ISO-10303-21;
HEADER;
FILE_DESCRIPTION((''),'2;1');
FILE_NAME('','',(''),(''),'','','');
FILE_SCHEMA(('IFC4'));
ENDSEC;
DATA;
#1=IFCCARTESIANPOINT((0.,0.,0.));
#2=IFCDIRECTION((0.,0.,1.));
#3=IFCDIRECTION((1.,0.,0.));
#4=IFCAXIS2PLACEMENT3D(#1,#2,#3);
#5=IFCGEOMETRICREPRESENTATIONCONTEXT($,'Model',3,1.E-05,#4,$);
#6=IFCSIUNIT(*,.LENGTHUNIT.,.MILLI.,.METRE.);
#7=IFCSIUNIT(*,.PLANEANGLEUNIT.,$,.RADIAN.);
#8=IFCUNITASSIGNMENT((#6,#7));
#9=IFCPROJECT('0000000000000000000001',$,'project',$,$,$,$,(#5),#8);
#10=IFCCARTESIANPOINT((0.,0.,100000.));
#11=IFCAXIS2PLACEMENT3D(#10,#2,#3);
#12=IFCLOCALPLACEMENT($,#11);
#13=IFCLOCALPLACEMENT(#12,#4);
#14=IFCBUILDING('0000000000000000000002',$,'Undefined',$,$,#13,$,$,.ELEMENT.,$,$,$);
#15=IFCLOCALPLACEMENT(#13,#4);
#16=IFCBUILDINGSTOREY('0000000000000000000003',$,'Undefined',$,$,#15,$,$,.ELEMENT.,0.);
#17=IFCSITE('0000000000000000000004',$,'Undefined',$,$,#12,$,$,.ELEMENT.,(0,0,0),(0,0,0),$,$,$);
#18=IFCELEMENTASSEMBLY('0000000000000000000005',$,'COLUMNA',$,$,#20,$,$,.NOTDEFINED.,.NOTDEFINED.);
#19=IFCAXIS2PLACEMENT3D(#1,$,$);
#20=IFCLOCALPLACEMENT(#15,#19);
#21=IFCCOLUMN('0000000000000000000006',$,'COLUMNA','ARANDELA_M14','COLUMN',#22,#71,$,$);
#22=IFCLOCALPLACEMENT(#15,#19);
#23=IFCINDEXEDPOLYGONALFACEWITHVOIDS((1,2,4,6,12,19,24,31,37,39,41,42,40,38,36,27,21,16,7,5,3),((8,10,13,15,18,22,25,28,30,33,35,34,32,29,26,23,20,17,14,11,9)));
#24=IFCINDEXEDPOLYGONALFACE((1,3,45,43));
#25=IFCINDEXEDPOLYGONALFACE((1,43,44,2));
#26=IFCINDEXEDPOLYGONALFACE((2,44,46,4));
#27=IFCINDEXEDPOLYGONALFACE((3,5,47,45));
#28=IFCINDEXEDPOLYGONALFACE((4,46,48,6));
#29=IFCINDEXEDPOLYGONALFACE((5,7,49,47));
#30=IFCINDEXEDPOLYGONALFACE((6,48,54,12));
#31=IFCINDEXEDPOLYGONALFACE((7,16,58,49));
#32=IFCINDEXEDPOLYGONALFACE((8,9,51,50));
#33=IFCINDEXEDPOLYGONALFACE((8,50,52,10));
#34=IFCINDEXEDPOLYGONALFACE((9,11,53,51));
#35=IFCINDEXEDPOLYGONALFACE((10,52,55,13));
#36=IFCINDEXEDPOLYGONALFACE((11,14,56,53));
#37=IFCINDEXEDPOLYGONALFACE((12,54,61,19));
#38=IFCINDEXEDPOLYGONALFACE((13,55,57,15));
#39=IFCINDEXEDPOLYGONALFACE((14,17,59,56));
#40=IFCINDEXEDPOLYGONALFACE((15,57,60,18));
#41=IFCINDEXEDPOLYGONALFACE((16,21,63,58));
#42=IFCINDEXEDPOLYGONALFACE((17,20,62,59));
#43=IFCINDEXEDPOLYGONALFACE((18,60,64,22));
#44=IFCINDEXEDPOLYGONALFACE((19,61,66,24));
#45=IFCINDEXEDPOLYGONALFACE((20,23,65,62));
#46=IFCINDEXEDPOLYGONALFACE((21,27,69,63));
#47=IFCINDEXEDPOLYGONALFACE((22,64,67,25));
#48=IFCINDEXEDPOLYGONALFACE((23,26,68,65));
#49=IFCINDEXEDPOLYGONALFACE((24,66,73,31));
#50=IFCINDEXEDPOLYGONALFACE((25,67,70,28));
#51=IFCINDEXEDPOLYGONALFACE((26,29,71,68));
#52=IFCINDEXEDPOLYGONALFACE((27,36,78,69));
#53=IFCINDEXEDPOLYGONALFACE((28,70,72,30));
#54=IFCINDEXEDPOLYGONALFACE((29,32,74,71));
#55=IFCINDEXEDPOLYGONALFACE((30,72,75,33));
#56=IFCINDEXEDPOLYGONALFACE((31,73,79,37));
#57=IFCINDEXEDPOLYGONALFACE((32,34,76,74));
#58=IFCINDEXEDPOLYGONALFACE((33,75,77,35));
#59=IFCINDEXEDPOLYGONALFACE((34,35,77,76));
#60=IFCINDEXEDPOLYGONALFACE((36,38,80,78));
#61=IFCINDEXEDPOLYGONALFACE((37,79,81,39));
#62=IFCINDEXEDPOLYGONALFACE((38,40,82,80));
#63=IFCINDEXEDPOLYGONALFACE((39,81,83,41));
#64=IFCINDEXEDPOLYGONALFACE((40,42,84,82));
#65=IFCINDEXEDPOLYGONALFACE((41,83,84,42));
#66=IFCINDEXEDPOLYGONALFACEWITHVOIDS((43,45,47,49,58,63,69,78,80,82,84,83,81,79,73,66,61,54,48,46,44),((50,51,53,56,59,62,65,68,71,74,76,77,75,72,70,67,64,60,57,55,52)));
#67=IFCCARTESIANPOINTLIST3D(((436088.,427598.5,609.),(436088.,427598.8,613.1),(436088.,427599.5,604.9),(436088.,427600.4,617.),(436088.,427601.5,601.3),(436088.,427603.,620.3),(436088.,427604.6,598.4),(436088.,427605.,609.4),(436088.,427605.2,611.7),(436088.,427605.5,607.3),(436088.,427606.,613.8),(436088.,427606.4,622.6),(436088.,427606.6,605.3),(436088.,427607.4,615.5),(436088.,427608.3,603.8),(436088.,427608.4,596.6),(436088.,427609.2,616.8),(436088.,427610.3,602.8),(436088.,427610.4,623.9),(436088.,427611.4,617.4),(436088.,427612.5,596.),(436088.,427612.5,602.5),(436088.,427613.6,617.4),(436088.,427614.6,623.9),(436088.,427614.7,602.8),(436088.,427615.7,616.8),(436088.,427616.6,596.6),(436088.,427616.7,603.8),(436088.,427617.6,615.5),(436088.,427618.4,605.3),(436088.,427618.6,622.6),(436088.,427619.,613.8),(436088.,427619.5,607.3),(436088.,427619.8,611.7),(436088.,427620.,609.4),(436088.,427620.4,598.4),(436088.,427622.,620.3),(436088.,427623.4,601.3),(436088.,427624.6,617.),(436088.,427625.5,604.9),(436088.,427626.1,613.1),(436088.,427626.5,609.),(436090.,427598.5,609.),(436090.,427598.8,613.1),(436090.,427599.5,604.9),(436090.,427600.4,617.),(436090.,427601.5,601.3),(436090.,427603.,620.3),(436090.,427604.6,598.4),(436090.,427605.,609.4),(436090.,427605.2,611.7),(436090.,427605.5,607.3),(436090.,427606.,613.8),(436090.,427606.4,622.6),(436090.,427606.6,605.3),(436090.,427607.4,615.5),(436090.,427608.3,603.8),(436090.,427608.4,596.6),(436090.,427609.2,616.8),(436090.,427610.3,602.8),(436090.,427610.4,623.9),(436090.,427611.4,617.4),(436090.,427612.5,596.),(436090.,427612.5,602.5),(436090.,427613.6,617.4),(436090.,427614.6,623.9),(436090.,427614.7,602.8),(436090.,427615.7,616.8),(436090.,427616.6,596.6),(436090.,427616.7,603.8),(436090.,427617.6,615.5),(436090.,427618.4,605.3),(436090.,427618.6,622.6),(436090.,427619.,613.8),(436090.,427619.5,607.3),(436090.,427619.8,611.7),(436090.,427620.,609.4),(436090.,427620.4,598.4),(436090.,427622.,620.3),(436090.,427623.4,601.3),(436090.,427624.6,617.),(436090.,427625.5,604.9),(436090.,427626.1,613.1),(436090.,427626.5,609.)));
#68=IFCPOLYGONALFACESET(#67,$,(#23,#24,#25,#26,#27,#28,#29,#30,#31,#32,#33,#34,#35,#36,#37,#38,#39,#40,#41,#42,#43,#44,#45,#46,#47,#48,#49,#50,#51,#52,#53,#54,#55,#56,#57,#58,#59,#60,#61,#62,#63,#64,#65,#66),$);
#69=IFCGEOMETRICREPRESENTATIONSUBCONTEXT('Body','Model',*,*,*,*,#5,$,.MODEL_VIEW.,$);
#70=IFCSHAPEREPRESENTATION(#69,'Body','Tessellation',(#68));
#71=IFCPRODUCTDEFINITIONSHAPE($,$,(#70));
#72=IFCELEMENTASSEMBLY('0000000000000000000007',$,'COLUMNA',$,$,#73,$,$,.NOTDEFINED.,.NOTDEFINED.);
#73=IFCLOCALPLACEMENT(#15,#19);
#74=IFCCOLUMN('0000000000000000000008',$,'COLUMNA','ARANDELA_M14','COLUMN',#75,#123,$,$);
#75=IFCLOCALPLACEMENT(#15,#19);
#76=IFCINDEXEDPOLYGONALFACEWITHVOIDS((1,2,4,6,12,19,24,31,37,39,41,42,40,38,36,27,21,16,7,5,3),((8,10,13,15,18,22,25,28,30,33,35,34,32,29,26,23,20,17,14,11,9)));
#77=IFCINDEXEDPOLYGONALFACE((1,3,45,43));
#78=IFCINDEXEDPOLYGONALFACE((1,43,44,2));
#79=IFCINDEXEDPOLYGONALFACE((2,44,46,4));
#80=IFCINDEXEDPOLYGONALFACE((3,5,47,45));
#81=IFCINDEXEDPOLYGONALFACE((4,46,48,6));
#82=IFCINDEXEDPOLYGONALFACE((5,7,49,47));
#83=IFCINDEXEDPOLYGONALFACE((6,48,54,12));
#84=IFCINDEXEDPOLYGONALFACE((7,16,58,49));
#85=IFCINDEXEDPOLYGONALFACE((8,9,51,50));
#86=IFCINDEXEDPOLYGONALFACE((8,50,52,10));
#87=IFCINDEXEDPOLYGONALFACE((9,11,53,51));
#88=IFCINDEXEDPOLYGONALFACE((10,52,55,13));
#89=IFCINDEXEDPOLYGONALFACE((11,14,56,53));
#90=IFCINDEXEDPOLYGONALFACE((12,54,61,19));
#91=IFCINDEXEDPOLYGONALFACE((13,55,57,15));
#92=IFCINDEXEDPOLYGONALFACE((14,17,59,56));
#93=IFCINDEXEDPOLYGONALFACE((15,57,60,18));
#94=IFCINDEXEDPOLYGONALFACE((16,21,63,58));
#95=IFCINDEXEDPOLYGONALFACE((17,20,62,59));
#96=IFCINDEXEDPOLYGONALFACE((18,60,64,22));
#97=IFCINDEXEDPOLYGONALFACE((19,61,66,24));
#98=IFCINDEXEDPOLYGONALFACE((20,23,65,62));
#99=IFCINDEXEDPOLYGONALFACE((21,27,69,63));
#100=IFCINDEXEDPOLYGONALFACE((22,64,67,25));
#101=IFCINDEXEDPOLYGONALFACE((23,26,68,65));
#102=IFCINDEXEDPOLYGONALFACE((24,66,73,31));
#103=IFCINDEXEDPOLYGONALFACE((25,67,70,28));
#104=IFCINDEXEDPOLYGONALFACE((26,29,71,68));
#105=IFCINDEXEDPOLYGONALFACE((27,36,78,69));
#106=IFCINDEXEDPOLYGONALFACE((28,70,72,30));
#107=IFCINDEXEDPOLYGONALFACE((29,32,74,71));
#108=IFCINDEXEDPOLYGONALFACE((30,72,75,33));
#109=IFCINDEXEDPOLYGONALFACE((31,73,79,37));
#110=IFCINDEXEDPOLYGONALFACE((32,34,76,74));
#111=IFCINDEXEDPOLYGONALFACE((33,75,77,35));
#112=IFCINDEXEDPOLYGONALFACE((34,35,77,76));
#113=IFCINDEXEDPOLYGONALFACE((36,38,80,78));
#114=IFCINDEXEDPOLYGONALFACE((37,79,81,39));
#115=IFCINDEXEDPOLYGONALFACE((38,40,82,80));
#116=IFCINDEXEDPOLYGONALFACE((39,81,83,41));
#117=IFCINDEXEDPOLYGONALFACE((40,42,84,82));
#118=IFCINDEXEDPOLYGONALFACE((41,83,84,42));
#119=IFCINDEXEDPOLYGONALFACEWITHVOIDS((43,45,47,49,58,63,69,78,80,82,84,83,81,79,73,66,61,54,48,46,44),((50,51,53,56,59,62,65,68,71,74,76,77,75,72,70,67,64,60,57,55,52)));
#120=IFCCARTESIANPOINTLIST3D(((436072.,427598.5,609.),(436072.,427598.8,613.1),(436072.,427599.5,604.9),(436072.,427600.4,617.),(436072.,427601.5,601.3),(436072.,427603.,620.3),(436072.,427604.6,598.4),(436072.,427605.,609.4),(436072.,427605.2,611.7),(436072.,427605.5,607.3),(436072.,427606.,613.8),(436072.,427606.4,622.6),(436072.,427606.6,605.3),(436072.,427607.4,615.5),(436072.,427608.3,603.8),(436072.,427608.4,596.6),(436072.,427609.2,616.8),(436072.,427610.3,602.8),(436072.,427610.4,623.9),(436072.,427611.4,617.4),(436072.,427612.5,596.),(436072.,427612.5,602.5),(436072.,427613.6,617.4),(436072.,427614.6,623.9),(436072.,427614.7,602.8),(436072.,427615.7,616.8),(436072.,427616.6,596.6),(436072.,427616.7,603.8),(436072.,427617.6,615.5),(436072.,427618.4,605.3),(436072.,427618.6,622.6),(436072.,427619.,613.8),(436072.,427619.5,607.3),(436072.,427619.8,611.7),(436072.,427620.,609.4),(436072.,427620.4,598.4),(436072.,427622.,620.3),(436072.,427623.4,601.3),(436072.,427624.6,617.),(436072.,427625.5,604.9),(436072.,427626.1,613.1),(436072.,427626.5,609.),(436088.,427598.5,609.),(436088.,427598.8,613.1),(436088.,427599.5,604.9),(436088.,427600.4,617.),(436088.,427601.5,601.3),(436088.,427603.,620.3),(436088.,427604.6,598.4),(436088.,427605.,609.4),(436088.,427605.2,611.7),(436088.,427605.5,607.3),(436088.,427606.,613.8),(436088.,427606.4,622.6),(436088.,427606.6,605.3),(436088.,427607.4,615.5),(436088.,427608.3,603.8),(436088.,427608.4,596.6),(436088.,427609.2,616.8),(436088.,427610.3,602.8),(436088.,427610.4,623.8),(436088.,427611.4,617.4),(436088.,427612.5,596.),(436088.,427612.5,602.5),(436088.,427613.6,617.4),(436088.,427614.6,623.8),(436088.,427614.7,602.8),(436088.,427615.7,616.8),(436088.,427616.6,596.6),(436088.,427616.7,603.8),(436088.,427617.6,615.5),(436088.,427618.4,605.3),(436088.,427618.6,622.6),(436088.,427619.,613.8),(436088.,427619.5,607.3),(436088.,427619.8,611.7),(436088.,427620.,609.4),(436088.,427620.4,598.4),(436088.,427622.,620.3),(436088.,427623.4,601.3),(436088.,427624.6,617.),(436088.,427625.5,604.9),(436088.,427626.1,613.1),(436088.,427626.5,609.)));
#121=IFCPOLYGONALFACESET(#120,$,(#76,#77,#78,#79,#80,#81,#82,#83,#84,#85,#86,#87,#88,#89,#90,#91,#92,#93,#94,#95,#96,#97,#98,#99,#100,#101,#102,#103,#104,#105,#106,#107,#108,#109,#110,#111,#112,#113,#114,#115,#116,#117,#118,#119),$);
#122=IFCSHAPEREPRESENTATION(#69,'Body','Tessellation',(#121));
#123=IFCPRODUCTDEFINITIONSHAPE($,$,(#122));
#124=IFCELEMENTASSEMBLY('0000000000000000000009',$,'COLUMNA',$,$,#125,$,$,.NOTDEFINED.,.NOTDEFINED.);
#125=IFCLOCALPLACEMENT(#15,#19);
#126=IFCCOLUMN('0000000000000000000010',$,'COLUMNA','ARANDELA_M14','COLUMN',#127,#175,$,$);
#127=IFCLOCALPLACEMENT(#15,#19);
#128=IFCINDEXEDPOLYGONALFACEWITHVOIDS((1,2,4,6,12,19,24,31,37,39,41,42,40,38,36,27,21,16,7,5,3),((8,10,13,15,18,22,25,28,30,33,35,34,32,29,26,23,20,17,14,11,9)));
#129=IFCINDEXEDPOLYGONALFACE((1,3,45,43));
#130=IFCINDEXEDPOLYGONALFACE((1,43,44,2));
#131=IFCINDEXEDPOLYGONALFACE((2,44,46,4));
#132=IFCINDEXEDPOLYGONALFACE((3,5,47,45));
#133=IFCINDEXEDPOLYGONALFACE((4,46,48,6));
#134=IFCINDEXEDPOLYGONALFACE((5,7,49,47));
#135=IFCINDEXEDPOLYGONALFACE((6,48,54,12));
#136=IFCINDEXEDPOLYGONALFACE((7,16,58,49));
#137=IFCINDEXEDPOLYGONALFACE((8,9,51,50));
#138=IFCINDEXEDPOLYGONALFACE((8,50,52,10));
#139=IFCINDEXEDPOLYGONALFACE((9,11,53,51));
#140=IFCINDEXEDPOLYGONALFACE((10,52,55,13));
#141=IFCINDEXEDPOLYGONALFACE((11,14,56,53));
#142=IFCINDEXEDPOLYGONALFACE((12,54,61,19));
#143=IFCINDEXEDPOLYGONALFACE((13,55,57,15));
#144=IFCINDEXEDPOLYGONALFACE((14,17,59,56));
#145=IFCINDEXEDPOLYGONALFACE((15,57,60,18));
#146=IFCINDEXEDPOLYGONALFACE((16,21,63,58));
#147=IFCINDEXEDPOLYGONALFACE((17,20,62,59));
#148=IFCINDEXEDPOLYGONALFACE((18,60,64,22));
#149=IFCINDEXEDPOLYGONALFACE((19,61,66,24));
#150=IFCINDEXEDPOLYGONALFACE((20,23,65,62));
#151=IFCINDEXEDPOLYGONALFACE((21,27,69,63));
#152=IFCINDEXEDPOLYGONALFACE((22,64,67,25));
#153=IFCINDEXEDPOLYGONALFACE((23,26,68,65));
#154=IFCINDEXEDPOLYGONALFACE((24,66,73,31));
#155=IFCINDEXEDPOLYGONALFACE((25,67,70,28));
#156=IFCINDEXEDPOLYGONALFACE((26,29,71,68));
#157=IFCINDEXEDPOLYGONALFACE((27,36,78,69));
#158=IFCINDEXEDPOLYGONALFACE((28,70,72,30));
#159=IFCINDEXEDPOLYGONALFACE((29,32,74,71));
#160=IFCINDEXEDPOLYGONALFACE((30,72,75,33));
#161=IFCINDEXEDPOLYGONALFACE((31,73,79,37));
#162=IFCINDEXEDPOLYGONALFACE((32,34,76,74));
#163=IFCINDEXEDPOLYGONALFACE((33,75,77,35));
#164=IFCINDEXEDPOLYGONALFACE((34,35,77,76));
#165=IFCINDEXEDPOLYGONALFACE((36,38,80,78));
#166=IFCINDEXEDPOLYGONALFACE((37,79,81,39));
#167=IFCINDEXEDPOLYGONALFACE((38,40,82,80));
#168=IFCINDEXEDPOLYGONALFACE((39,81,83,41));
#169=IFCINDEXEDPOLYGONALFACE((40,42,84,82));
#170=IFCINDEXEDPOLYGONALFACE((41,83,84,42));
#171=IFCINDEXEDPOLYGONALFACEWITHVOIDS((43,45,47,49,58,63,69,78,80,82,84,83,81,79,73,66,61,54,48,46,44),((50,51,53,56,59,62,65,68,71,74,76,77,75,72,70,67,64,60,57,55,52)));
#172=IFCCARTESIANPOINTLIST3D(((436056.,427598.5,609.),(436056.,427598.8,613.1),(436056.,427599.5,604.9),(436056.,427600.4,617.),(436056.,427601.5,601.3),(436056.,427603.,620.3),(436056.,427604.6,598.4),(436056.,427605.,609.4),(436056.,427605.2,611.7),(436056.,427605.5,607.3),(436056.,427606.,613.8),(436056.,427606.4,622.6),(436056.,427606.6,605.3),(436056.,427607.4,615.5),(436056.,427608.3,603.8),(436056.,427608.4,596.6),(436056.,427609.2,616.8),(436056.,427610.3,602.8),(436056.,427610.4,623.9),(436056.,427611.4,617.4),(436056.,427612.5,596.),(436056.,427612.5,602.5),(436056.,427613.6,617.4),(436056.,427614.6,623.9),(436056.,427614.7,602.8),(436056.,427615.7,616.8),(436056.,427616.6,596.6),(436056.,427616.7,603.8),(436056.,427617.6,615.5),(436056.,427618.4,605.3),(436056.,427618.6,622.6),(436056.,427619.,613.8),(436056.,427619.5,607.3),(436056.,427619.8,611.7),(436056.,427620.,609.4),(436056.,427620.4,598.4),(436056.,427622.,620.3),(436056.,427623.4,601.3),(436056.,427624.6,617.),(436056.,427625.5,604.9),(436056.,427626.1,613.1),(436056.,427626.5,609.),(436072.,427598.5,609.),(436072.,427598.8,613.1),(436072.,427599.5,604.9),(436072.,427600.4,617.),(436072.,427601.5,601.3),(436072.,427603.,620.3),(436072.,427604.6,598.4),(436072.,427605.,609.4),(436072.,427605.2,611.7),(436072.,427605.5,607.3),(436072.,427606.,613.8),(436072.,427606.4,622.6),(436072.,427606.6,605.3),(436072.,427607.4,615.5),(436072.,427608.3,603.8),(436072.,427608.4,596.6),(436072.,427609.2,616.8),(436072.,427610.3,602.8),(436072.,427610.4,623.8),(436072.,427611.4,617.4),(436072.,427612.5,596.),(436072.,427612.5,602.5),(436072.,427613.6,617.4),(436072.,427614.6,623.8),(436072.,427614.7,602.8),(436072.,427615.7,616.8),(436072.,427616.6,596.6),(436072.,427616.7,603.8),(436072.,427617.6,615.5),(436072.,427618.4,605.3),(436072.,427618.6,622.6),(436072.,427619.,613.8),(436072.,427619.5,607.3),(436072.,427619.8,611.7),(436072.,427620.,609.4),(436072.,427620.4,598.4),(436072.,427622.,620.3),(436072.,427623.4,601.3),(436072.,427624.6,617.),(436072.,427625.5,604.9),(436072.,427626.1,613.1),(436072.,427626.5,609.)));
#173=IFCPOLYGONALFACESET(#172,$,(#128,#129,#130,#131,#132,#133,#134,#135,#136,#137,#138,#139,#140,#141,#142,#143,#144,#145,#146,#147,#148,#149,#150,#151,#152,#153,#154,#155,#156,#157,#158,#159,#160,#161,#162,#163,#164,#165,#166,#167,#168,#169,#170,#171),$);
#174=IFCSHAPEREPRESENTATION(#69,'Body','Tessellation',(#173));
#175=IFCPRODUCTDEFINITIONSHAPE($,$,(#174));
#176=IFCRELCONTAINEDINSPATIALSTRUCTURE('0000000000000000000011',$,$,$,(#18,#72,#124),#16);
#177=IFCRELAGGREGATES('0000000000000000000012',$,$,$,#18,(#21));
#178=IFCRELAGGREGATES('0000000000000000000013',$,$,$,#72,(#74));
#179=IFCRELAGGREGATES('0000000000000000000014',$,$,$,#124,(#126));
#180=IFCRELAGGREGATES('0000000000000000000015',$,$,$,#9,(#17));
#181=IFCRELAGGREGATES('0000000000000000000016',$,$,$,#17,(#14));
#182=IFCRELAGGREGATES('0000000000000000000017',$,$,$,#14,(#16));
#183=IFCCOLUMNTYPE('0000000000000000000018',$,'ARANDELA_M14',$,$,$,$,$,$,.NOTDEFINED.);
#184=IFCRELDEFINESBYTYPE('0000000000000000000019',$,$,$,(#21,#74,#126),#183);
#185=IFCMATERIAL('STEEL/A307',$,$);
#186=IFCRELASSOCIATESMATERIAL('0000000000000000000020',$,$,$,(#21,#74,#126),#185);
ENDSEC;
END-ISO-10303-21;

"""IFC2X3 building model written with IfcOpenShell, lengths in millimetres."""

from ifc_helpers import new_model, si_unit, frame, origin_with_axes, origin_2d_with_axis, place, context, subcontext, project, spatial, hollow_circle, extrude, material, type_object, element, aggregate, save


model = new_model("IFC2X3")

# Units and contexts
model_context = context("Model", 3, precision=1e-05, world=origin_with_axes())
body_context = subcontext(model_context, "Body", "Model", "MODEL_VIEW")
ifc_project = project(units=[si_unit("LENGTHUNIT", "METRE", prefix="MILLI"), si_unit("PLANEANGLEUNIT", "RADIAN")], contexts=[model_context])

# Site, building, storey
site_placement = place(None, frame((0.0, 0.0, 100000.0), z_axis=(0.0, 0.0, 1.0), x_axis=(1.0, 0.0, 0.0)))
site = spatial("IfcSite", under=ifc_project, at=site_placement, Name="Undefined", CompositionType="ELEMENT", RefLatitude=(0, 0, 0), RefLongitude=(0, 0, 0))
building_placement = place(site_placement, origin_with_axes())
building = spatial("IfcBuilding", under=site, at=building_placement, Name="Undefined", CompositionType="ELEMENT")
storey_placement = place(building_placement, origin_with_axes())
storey = spatial("IfcBuildingStorey", under=building, at=storey_placement, Name="Undefined", CompositionType="ELEMENT", Elevation=0.0)

# Element assemblies, columns
assembly_1_placement = place(storey_placement, origin_with_axes())
assembly_1 = element("IfcElementAssembly", 1, at=assembly_1_placement, inside=storey, Name="COLUMNA", AssemblyPlace="NOTDEFINED", PredefinedType="NOTDEFINED")
ifc_material_1 = material(Name="STEEL/A307")
column_type_1 = type_object("IfcColumnType", Name="ARANDELA_M14", PredefinedType="NOTDEFINED")
column_1_placement = place(assembly_1_placement, frame((436090.0, 427612.5, 610.0), z_axis=(-1.0, 0.0, 0.000285), x_axis=(0.0, 1.0, 0.0)))
column_1 = element("IfcColumn", 2, at=column_1_placement, type_object=column_type_1, material=ifc_material_1, Name="COLUMNA", Description="ARANDELA_M14", ObjectType="COLUMN", context=body_context, shape_type="SweptSolid", body=[
    extrude(hollow_circle(Radius=14.0, WallThickness=6.5, at=origin_2d_with_axis()), frame((0.0, 0.0, 2.0), z_axis=(0.0, 0.0, -1.0), x_axis=(0.0, 1.0, 0.0)), (0.0, 0.0, 1.0), 2.0),
])
aggregate(assembly_1, [column_1])
assembly_2_placement = place(storey_placement, origin_with_axes())
assembly_2 = element("IfcElementAssembly", 3, at=assembly_2_placement, inside=storey, Name="COLUMNA", AssemblyPlace="NOTDEFINED", PredefinedType="NOTDEFINED")
column_2_placement = place(assembly_2_placement, frame((436088.0, 427612.5, 610.0), z_axis=(-1.0, 0.0, 0.000285), x_axis=(0.0, 1.0, 0.0)))
column_2 = element("IfcColumn", 4, at=column_2_placement, type_object=column_type_1, material=ifc_material_1, Name="COLUMNA", Description="ARANDELA_M14", ObjectType="COLUMN", context=body_context, shape_type="SweptSolid", body=[
    extrude(hollow_circle(Radius=14.0, WallThickness=6.5, at=origin_2d_with_axis()), frame((0.0, 0.0, 16.0), z_axis=(0.0, 0.0, -1.0), x_axis=(0.0, 1.0, 0.0)), (0.0, 0.0, 1.0), 16.0),
])
aggregate(assembly_2, [column_2])
assembly_3_placement = place(storey_placement, origin_with_axes())
assembly_3 = element("IfcElementAssembly", 5, at=assembly_3_placement, inside=storey, Name="COLUMNA", AssemblyPlace="NOTDEFINED", PredefinedType="NOTDEFINED")
column_3_placement = place(assembly_3_placement, frame((436072.0, 427612.5, 610.0), z_axis=(-1.0, 0.0, 0.000285), x_axis=(0.0, 1.0, 0.0)))
column_3 = element("IfcColumn", 6, at=column_3_placement, type_object=column_type_1, material=ifc_material_1, Name="COLUMNA", Description="ARANDELA_M14", ObjectType="COLUMN", context=body_context, shape_type="SweptSolid", body=[
    extrude(hollow_circle(Radius=14.0, WallThickness=6.5, at=origin_2d_with_axis()), frame((0.0, 0.0, 16.0), z_axis=(0.0, 0.0, -1.0), x_axis=(0.0, 1.0, 0.0)), (0.0, 0.0, 1.0), 16.0),
])
aggregate(assembly_3, [column_3])

save(model, "model.ifc")
